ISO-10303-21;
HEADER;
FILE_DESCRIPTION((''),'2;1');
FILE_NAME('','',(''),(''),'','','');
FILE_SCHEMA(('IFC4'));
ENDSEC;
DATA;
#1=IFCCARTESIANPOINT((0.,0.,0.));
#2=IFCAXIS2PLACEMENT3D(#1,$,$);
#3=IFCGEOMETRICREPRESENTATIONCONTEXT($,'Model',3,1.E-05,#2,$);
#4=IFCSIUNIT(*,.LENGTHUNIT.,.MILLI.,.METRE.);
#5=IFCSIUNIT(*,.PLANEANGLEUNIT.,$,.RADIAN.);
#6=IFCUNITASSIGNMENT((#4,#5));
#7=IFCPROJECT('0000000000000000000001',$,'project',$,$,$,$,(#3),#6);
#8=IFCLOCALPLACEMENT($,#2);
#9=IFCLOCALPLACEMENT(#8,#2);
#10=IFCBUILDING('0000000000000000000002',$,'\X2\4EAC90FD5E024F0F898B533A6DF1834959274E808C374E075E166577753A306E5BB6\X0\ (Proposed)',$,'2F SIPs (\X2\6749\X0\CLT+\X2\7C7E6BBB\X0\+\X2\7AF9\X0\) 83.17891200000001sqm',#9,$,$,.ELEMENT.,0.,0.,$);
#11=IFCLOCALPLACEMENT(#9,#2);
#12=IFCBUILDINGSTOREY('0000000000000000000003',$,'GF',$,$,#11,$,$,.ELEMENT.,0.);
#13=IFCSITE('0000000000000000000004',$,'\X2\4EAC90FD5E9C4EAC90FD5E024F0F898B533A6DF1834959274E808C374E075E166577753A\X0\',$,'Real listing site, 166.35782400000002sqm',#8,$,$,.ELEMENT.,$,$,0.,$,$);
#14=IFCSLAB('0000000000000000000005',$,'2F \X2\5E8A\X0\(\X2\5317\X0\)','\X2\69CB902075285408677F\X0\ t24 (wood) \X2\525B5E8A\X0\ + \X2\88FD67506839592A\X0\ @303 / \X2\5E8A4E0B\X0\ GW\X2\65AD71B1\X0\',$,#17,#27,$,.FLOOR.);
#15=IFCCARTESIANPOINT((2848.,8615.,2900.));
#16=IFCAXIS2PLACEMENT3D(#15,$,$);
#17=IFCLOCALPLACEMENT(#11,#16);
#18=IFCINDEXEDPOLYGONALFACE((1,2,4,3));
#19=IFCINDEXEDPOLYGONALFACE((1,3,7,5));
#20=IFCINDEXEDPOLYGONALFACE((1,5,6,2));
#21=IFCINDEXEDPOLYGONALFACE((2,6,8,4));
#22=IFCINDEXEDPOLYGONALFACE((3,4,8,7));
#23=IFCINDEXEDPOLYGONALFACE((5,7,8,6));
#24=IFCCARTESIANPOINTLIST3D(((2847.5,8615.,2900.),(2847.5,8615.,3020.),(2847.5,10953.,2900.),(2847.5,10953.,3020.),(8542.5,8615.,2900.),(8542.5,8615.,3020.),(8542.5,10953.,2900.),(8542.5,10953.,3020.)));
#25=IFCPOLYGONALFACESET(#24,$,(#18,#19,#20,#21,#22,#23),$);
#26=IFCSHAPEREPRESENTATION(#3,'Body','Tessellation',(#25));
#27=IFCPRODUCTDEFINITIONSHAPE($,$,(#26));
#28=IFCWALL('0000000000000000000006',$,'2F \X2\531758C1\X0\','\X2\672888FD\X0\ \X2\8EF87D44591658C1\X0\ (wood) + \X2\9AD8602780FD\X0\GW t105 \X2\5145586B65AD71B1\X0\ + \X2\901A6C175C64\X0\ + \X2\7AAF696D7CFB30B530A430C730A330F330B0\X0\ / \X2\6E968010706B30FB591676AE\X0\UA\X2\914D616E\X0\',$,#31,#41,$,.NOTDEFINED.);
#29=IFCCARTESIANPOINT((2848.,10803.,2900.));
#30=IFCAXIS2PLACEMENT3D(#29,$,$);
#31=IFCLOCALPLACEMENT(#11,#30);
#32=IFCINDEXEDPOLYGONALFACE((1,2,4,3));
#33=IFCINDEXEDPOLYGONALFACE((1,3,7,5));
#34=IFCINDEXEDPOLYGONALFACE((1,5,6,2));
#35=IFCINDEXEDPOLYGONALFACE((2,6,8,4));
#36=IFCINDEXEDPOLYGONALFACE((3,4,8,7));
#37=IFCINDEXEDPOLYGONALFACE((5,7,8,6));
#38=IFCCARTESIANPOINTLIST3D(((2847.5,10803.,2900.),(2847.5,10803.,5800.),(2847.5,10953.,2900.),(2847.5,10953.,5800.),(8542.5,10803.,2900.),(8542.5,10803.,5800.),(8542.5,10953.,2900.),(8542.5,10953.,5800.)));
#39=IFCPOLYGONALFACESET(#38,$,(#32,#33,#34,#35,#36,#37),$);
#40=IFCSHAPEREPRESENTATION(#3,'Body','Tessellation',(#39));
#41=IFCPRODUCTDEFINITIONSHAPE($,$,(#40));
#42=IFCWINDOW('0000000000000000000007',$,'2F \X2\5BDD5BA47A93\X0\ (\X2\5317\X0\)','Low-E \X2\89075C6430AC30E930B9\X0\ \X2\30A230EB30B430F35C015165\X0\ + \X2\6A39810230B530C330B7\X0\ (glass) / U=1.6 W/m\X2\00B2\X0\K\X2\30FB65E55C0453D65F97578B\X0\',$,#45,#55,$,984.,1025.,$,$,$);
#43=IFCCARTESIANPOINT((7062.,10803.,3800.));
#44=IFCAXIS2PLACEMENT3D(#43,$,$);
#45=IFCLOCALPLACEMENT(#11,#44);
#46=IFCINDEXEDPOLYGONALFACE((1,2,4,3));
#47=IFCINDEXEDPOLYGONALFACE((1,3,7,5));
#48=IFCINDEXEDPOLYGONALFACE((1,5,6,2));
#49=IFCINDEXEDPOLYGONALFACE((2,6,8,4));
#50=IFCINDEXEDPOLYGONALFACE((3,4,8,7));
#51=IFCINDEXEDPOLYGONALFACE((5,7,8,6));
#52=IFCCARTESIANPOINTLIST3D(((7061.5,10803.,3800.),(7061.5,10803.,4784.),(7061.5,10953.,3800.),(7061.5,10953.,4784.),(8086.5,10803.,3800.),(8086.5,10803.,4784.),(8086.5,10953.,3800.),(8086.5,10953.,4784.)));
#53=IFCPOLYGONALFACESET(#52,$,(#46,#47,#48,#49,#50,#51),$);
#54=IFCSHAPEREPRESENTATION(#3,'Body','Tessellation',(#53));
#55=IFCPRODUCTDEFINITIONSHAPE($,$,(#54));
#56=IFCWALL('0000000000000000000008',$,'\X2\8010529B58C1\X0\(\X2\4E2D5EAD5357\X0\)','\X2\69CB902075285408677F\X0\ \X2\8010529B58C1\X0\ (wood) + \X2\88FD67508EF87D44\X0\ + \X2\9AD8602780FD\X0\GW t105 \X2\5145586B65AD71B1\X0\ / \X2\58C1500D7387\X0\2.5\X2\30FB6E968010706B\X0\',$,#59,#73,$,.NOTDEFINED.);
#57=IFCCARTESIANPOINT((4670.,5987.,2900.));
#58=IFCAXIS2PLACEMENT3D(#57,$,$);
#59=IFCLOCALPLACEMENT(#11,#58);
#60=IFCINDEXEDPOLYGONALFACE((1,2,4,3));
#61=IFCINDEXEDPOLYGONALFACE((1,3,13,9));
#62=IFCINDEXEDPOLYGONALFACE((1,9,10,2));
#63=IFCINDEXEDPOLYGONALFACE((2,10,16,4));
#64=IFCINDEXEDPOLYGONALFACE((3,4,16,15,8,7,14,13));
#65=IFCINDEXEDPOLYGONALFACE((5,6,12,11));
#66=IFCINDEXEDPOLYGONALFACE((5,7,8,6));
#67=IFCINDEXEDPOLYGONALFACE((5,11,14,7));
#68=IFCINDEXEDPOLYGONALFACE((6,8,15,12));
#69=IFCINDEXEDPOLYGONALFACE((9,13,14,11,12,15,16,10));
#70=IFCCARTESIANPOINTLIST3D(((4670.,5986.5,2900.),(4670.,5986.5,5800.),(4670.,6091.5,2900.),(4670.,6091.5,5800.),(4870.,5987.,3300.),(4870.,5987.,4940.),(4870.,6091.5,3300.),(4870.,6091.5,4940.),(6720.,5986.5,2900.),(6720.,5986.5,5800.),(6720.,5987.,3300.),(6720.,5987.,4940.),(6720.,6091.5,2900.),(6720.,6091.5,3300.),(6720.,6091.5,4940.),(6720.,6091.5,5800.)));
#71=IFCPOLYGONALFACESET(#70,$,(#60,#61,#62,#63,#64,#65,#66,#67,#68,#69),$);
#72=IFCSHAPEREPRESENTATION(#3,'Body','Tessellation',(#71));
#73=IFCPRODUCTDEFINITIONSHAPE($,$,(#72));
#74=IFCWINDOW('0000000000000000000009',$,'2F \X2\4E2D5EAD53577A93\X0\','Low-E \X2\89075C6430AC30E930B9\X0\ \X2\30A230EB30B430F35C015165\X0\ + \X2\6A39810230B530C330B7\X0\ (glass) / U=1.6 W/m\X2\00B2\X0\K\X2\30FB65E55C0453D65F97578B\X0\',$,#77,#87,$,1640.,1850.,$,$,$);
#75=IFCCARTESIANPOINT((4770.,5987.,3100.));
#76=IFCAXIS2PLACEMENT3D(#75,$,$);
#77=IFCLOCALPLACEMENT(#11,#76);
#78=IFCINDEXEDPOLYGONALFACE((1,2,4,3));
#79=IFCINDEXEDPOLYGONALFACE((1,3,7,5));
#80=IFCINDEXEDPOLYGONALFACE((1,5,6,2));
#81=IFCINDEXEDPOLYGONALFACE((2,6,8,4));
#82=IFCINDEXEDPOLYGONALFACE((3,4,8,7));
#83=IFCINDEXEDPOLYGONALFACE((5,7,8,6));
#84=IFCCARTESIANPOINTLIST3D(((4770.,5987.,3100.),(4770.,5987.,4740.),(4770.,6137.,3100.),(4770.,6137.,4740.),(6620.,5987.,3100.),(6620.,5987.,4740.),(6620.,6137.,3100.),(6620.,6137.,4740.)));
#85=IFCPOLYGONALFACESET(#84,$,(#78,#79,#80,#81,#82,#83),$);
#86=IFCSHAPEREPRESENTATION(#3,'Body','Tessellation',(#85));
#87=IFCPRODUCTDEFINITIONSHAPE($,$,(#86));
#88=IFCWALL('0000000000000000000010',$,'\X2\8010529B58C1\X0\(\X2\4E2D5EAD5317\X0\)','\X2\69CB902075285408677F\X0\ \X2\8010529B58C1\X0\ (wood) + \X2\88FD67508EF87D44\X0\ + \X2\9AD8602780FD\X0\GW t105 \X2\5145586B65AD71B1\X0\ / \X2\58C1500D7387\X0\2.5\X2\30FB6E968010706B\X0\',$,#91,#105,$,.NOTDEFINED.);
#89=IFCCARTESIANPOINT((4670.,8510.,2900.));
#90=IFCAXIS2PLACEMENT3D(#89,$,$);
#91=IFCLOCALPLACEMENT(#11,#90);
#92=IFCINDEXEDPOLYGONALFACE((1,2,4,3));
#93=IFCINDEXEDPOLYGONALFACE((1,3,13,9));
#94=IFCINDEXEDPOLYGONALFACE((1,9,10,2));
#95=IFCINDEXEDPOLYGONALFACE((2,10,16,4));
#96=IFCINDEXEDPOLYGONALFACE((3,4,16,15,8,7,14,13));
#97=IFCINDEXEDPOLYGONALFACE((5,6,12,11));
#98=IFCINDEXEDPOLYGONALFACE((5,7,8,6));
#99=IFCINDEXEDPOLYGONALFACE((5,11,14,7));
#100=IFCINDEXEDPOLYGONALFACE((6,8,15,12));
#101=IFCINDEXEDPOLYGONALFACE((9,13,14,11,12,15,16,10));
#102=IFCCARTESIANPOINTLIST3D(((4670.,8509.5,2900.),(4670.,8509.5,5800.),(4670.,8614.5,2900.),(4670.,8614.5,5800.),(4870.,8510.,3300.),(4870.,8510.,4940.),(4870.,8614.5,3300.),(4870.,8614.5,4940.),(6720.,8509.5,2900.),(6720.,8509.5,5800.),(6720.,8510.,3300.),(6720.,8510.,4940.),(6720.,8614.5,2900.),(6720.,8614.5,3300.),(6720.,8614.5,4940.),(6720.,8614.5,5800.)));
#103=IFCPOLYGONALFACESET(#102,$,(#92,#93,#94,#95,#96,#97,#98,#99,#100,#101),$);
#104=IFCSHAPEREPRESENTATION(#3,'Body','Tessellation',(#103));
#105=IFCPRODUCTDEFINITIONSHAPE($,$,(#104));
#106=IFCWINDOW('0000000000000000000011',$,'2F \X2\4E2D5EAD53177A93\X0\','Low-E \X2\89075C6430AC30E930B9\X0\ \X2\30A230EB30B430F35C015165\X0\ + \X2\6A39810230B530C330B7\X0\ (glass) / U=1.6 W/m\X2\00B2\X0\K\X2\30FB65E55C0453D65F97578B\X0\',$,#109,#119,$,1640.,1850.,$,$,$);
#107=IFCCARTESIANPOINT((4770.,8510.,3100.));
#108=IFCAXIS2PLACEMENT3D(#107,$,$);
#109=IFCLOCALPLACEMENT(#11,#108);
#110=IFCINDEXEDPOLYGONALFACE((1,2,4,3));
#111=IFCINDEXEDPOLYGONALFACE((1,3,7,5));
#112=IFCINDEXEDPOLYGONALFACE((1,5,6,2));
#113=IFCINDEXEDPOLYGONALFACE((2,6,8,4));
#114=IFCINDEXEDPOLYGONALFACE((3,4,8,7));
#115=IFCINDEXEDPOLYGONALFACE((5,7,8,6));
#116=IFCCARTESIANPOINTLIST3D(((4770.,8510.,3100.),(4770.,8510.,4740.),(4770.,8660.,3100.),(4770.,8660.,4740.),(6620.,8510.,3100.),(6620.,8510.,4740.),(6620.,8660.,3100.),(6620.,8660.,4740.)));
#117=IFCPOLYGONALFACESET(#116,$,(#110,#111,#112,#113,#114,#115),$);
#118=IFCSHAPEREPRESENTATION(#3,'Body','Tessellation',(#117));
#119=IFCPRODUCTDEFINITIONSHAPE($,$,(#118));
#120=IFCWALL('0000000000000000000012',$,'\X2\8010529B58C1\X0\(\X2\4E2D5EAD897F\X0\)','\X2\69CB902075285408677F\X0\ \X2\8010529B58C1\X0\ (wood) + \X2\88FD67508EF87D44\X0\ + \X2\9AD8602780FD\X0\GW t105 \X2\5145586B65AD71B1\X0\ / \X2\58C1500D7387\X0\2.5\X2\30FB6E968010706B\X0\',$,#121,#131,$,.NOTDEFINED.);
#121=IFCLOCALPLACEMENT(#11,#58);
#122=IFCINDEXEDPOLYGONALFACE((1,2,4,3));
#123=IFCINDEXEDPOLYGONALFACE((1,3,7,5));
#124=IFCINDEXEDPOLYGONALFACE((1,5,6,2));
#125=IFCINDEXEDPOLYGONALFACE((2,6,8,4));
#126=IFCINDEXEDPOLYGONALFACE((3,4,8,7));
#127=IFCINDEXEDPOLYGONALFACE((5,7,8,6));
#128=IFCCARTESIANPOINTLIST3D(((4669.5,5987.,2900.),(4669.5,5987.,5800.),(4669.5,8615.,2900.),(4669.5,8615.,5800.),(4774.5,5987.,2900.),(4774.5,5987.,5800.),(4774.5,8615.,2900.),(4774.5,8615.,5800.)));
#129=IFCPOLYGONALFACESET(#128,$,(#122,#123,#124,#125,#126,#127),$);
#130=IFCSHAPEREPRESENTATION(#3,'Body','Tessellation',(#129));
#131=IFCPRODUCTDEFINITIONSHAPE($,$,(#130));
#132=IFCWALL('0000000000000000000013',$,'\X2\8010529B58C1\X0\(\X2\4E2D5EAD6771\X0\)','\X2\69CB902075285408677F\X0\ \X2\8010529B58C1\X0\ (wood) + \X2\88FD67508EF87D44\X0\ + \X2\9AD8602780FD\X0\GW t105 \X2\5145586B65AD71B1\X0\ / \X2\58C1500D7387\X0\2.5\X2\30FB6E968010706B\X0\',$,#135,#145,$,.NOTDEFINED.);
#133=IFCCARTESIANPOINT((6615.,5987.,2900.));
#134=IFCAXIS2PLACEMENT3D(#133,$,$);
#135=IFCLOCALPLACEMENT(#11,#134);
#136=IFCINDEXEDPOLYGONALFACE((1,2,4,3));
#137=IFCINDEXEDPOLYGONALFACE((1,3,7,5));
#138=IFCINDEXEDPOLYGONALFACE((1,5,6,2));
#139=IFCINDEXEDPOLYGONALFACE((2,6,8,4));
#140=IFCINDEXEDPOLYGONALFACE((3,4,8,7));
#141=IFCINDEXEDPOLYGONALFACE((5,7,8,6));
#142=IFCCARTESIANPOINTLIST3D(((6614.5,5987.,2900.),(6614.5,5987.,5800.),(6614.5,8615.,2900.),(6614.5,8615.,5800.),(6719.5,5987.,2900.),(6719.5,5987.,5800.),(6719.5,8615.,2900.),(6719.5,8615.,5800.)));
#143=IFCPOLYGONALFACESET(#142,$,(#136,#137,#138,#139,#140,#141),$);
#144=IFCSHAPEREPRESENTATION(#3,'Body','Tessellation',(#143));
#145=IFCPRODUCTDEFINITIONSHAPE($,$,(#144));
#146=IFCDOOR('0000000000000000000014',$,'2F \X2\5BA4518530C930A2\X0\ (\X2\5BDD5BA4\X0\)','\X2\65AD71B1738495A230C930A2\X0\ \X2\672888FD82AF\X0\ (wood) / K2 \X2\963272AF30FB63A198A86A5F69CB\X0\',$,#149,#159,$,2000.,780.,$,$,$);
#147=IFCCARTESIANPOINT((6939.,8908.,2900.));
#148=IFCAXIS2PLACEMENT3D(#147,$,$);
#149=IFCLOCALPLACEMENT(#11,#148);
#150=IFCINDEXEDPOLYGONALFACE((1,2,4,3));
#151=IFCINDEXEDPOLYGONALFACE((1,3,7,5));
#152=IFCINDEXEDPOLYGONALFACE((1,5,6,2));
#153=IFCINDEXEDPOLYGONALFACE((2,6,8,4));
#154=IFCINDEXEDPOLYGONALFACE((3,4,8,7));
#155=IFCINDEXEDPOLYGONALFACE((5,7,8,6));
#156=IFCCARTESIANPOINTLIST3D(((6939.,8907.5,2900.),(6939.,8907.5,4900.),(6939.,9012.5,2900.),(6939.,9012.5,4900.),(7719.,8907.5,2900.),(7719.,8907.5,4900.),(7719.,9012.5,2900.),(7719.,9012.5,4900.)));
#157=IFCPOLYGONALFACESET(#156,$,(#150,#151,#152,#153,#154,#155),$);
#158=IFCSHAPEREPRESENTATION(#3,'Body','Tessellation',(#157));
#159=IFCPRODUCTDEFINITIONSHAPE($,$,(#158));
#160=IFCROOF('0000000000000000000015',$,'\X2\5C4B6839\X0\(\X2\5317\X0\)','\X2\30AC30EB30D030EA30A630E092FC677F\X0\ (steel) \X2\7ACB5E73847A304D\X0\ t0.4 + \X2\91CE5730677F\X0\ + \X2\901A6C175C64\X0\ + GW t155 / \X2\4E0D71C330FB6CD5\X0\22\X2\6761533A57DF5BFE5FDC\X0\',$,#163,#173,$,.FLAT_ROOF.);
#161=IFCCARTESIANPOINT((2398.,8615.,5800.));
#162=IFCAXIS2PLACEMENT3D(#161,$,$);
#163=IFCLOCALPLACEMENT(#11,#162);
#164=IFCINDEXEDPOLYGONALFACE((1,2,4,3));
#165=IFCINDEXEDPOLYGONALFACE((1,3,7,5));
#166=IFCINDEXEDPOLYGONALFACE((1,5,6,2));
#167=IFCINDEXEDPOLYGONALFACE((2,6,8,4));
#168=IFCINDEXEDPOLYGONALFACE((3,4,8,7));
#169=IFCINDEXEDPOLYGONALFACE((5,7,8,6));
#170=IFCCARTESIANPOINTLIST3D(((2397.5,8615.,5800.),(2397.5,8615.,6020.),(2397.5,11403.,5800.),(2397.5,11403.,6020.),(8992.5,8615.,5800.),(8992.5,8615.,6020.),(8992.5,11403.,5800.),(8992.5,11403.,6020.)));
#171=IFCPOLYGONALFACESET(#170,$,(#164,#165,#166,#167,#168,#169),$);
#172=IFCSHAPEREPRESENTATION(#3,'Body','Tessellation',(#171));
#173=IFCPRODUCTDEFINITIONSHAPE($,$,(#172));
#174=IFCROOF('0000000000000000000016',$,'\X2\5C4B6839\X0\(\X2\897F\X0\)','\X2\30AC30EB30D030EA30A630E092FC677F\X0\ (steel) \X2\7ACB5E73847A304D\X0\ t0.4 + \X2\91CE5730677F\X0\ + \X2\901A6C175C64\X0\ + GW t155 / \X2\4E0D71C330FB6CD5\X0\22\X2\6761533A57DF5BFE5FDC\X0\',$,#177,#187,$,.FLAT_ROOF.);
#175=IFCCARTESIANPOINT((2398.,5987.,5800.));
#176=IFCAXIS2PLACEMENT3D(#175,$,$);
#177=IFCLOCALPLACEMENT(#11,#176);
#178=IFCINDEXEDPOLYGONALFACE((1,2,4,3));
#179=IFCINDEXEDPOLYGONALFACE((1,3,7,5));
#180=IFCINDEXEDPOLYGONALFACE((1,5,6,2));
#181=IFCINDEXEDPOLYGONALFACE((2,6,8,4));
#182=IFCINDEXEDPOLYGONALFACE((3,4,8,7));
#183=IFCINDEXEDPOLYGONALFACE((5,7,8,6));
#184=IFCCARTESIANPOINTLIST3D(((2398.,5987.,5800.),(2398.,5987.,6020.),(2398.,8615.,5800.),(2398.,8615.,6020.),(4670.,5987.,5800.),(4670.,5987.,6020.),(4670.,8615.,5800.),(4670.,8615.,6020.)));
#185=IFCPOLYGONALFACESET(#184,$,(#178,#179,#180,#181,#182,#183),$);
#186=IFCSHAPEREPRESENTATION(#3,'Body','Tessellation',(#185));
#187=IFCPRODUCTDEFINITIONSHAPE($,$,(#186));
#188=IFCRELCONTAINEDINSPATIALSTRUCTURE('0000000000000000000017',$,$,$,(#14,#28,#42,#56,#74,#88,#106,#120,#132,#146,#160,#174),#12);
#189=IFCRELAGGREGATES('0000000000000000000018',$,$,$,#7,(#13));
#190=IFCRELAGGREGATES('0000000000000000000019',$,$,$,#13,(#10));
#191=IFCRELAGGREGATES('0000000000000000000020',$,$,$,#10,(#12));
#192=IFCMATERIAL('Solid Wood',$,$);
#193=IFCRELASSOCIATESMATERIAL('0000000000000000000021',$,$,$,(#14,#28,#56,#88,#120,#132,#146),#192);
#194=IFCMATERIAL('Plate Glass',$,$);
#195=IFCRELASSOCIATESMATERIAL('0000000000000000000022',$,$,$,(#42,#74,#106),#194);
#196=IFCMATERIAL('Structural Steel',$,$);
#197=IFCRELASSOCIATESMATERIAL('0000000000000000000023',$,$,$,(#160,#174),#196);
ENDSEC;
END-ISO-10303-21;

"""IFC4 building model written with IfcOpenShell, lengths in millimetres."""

from ifc_helpers import new_model, si_unit, frame, frame_2d, origin, place, context, project, spatial, rectangle, extrude, material, element, fill, save


model = new_model("IFC4")

# Units and contexts
model_context = context("Model", 3, precision=1e-05, world=origin())
ifc_project = project(units=[si_unit("LENGTHUNIT", "METRE", prefix="MILLI"), si_unit("PLANEANGLEUNIT", "RADIAN")], contexts=[model_context])

# Site, building, storey
site_placement = place(None, origin())
site = spatial("IfcSite", under=ifc_project, at=site_placement, Name="京都府京都市伏見区深草大亀谷万帖敷町", ObjectType="Real listing site, 166.35782400000002sqm", CompositionType="ELEMENT", RefElevation=0.0)
building_placement = place(site_placement, origin())
building = spatial("IfcBuilding", under=site, at=building_placement, Name="京都市伏見区深草大亀谷万帖敷町の家 (Proposed)", ObjectType="2F SIPs (杉CLT+籾殻+竹) 83.17891200000001sqm", CompositionType="ELEMENT", ElevationOfRefHeight=0.0, ElevationOfTerrain=0.0)
storey_placement = place(building_placement, origin())
storey = spatial("IfcBuildingStorey", under=building, at=storey_placement, Name="GF", CompositionType="ELEMENT", Elevation=0.0)

# Slab
ifc_material_1 = material(Name="Solid Wood")
slab_placement = place(storey_placement, frame((2848.0, 8615.0, 2900.0)))
element("IfcSlab", 1, at=slab_placement, inside=storey, material=ifc_material_1, Name="2F 床(北)", Description="構造用合板 t24 (wood) 剛床 + 製材根太 @303 / 床下 GW断熱", PredefinedType="FLOOR", context=model_context, shape_type="SweptSolid", body=[
    extrude(rectangle(XDim=5695.0, YDim=2338.0, at=frame_2d((2847.0, 1169.0))), frame((2848.0, 8615.0, 2900.0)), (0.0, 0.0, 1.0), 120.0),
])

# Walls, openings, windows
wall_1_placement = place(storey_placement, frame((2848.0, 10803.0, 2900.0)))
wall_1 = element("IfcWall", 2, at=wall_1_placement, inside=storey, material=ifc_material_1, Name="2F 北壁", Description="木製 軸組外壁 (wood) + 高性能GW t105 充填断熱 + 通気層 + 窯業系サイディング / 準耐火・外皮UA配慮", PredefinedType="NOTDEFINED", context=model_context, shape_type="SweptSolid", body=[
    extrude(rectangle(XDim=5695.0, YDim=150.0, at=frame_2d((2847.0, 75.0))), frame((2848.0, 10803.0, 2900.0)), (0.0, 0.0, 1.0), 2900.0),
])
opening_1_placement = place(storey_placement, frame((7062.0, 10803.0, 3800.0)))
opening_1 = element("IfcOpeningElement", 3, at=opening_1_placement, cuts=wall_1, PredefinedType="NOTDEFINED", context=model_context, shape_type="SweptSolid", body=[
    extrude(rectangle(XDim=1025.0, YDim=150.0, at=frame_2d((512.0, 75.0))), frame((7062.0, 10803.0, 3800.0)), (0.0, 0.0, 1.0), 984.0),
])
ifc_material_2 = material(Name="Plate Glass")
window_1_placement = place(storey_placement, frame((7062.0, 10803.0, 3800.0)))
window_1 = element("IfcWindow", 4, at=window_1_placement, inside=storey, material=ifc_material_2, Name="2F 寝室窓 (北)", Description="Low-E 複層ガラス アルゴン封入 + 樹脂サッシ (glass) / U=1.6 W/m²K・日射取得型", OverallHeight=984.0, OverallWidth=1025.0, context=model_context, shape_type="SweptSolid", body=[
    extrude(rectangle(XDim=1025.0, YDim=150.0, at=frame_2d((512.0, 75.0))), frame((7062.0, 10803.0, 3800.0)), (0.0, 0.0, 1.0), 984.0),
])
fill(opening_1, window_1)
wall_2_placement = place(storey_placement, frame((4670.0, 5987.0, 2900.0)))
wall_2 = element("IfcWall", 5, at=wall_2_placement, inside=storey, material=ifc_material_1, Name="耐力壁(中庭南)", Description="構造用合板 耐力壁 (wood) + 製材軸組 + 高性能GW t105 充填断熱 / 壁倍率2.5・準耐火", PredefinedType="NOTDEFINED", context=model_context, shape_type="SweptSolid", body=[
    extrude(rectangle(XDim=2050.0, YDim=105.0, at=frame_2d((1025.0, 52.0))), frame((4670.0, 5987.0, 2900.0)), (0.0, 0.0, 1.0), 2900.0),
])
opening_2_placement = place(storey_placement, frame((4770.0, 5987.0, 3100.0)))
opening_2 = element("IfcOpeningElement", 6, at=opening_2_placement, cuts=wall_2, PredefinedType="NOTDEFINED", context=model_context, shape_type="SweptSolid", body=[
    extrude(rectangle(XDim=1850.0, YDim=150.0, at=frame_2d((925.0, 75.0))), frame((4770.0, 5987.0, 3100.0)), (0.0, 0.0, 1.0), 1640.0),
])
window_2_placement = place(storey_placement, frame((4770.0, 5987.0, 3100.0)))
window_2 = element("IfcWindow", 7, at=window_2_placement, inside=storey, material=ifc_material_2, Name="2F 中庭南窓", Description="Low-E 複層ガラス アルゴン封入 + 樹脂サッシ (glass) / U=1.6 W/m²K・日射取得型", OverallHeight=1640.0, OverallWidth=1850.0, context=model_context, shape_type="SweptSolid", body=[
    extrude(rectangle(XDim=1850.0, YDim=150.0, at=frame_2d((925.0, 75.0))), frame((4770.0, 5987.0, 3100.0)), (0.0, 0.0, 1.0), 1640.0),
])
fill(opening_2, window_2)
wall_3_placement = place(storey_placement, frame((4670.0, 8510.0, 2900.0)))
wall_3 = element("IfcWall", 8, at=wall_3_placement, inside=storey, material=ifc_material_1, Name="耐力壁(中庭北)", Description="構造用合板 耐力壁 (wood) + 製材軸組 + 高性能GW t105 充填断熱 / 壁倍率2.5・準耐火", PredefinedType="NOTDEFINED", context=model_context, shape_type="SweptSolid", body=[
    extrude(rectangle(XDim=2050.0, YDim=105.0, at=frame_2d((1025.0, 52.0))), frame((4670.0, 8510.0, 2900.0)), (0.0, 0.0, 1.0), 2900.0),
])
opening_3_placement = place(storey_placement, frame((4770.0, 8510.0, 3100.0)))
opening_3 = element("IfcOpeningElement", 9, at=opening_3_placement, cuts=wall_3, PredefinedType="NOTDEFINED", context=model_context, shape_type="SweptSolid", body=[
    extrude(rectangle(XDim=1850.0, YDim=150.0, at=frame_2d((925.0, 75.0))), frame((4770.0, 8510.0, 3100.0)), (0.0, 0.0, 1.0), 1640.0),
])
window_3_placement = place(storey_placement, frame((4770.0, 8510.0, 3100.0)))
window_3 = element("IfcWindow", 10, at=window_3_placement, inside=storey, material=ifc_material_2, Name="2F 中庭北窓", Description="Low-E 複層ガラス アルゴン封入 + 樹脂サッシ (glass) / U=1.6 W/m²K・日射取得型", OverallHeight=1640.0, OverallWidth=1850.0, context=model_context, shape_type="SweptSolid", body=[
    extrude(rectangle(XDim=1850.0, YDim=150.0, at=frame_2d((925.0, 75.0))), frame((4770.0, 8510.0, 3100.0)), (0.0, 0.0, 1.0), 1640.0),
])
fill(opening_3, window_3)

# Walls
wall_4_placement = place(storey_placement, frame((4670.0, 5987.0, 2900.0)))
element("IfcWall", 11, at=wall_4_placement, inside=storey, material=ifc_material_1, Name="耐力壁(中庭西)", Description="構造用合板 耐力壁 (wood) + 製材軸組 + 高性能GW t105 充填断熱 / 壁倍率2.5・準耐火", PredefinedType="NOTDEFINED", context=model_context, shape_type="SweptSolid", body=[
    extrude(rectangle(XDim=105.0, YDim=2628.0, at=frame_2d((52.0, 1314.0))), frame((4670.0, 5987.0, 2900.0)), (0.0, 0.0, 1.0), 2900.0),
])
wall_5_placement = place(storey_placement, frame((6615.0, 5987.0, 2900.0)))
element("IfcWall", 12, at=wall_5_placement, inside=storey, material=ifc_material_1, Name="耐力壁(中庭東)", Description="構造用合板 耐力壁 (wood) + 製材軸組 + 高性能GW t105 充填断熱 / 壁倍率2.5・準耐火", PredefinedType="NOTDEFINED", context=model_context, shape_type="SweptSolid", body=[
    extrude(rectangle(XDim=105.0, YDim=2628.0, at=frame_2d((52.0, 1314.0))), frame((6615.0, 5987.0, 2900.0)), (0.0, 0.0, 1.0), 2900.0),
])

# Door
door_placement = place(storey_placement, frame((6939.0, 8908.0, 2900.0)))
element("IfcDoor", 13, at=door_placement, inside=storey, material=ifc_material_1, Name="2F 室内ドア (寝室)", Description="断熱玄関ドア 木製芯 (wood) / K2 防犯・採風機構", OverallHeight=2000.0, OverallWidth=780.0, context=model_context, shape_type="SweptSolid", body=[
    extrude(rectangle(XDim=780.0, YDim=105.0, at=frame_2d((390.0, 52.0))), frame((6939.0, 8908.0, 2900.0)), (0.0, 0.0, 1.0), 2000.0),
])

# Roofs
ifc_material_3 = material(Name="Structural Steel")
for number, where, name in (
    (14, (2398.0, 8615.0, 5800.0), "屋根(北)"),
):
    element("IfcRoof", number, at=place(storey_placement, frame(where)), inside=storey, material=ifc_material_3, Name=name, Description="ガルバリウム鋼板 (steel) 立平葺き t0.4 + 野地板 + 通気層 + GW t155 / 不燃・法22条区域対応", PredefinedType="FLAT_ROOF", context=model_context, shape_type="SweptSolid", body=[
        extrude(rectangle(XDim=6595.0, YDim=2788.0, at=frame_2d((3297.0, 1394.0))), frame((2398.0, 8615.0, 5800.0)), (0.0, 0.0, 1.0), 220.0),
    ])
roof_1_placement = place(storey_placement, frame((2398.0, 5987.0, 5800.0)))
element("IfcRoof", 15, at=roof_1_placement, inside=storey, material=ifc_material_3, Name="屋根(西)", Description="ガルバリウム鋼板 (steel) 立平葺き t0.4 + 野地板 + 通気層 + GW t155 / 不燃・法22条区域対応", PredefinedType="FLAT_ROOF", context=model_context, shape_type="SweptSolid", body=[
    extrude(rectangle(XDim=2272.0, YDim=2628.0, at=frame_2d((1136.0, 1314.0))), frame((2398.0, 5987.0, 5800.0)), (0.0, 0.0, 1.0), 220.0),
])

save(model, "model.ifc")
